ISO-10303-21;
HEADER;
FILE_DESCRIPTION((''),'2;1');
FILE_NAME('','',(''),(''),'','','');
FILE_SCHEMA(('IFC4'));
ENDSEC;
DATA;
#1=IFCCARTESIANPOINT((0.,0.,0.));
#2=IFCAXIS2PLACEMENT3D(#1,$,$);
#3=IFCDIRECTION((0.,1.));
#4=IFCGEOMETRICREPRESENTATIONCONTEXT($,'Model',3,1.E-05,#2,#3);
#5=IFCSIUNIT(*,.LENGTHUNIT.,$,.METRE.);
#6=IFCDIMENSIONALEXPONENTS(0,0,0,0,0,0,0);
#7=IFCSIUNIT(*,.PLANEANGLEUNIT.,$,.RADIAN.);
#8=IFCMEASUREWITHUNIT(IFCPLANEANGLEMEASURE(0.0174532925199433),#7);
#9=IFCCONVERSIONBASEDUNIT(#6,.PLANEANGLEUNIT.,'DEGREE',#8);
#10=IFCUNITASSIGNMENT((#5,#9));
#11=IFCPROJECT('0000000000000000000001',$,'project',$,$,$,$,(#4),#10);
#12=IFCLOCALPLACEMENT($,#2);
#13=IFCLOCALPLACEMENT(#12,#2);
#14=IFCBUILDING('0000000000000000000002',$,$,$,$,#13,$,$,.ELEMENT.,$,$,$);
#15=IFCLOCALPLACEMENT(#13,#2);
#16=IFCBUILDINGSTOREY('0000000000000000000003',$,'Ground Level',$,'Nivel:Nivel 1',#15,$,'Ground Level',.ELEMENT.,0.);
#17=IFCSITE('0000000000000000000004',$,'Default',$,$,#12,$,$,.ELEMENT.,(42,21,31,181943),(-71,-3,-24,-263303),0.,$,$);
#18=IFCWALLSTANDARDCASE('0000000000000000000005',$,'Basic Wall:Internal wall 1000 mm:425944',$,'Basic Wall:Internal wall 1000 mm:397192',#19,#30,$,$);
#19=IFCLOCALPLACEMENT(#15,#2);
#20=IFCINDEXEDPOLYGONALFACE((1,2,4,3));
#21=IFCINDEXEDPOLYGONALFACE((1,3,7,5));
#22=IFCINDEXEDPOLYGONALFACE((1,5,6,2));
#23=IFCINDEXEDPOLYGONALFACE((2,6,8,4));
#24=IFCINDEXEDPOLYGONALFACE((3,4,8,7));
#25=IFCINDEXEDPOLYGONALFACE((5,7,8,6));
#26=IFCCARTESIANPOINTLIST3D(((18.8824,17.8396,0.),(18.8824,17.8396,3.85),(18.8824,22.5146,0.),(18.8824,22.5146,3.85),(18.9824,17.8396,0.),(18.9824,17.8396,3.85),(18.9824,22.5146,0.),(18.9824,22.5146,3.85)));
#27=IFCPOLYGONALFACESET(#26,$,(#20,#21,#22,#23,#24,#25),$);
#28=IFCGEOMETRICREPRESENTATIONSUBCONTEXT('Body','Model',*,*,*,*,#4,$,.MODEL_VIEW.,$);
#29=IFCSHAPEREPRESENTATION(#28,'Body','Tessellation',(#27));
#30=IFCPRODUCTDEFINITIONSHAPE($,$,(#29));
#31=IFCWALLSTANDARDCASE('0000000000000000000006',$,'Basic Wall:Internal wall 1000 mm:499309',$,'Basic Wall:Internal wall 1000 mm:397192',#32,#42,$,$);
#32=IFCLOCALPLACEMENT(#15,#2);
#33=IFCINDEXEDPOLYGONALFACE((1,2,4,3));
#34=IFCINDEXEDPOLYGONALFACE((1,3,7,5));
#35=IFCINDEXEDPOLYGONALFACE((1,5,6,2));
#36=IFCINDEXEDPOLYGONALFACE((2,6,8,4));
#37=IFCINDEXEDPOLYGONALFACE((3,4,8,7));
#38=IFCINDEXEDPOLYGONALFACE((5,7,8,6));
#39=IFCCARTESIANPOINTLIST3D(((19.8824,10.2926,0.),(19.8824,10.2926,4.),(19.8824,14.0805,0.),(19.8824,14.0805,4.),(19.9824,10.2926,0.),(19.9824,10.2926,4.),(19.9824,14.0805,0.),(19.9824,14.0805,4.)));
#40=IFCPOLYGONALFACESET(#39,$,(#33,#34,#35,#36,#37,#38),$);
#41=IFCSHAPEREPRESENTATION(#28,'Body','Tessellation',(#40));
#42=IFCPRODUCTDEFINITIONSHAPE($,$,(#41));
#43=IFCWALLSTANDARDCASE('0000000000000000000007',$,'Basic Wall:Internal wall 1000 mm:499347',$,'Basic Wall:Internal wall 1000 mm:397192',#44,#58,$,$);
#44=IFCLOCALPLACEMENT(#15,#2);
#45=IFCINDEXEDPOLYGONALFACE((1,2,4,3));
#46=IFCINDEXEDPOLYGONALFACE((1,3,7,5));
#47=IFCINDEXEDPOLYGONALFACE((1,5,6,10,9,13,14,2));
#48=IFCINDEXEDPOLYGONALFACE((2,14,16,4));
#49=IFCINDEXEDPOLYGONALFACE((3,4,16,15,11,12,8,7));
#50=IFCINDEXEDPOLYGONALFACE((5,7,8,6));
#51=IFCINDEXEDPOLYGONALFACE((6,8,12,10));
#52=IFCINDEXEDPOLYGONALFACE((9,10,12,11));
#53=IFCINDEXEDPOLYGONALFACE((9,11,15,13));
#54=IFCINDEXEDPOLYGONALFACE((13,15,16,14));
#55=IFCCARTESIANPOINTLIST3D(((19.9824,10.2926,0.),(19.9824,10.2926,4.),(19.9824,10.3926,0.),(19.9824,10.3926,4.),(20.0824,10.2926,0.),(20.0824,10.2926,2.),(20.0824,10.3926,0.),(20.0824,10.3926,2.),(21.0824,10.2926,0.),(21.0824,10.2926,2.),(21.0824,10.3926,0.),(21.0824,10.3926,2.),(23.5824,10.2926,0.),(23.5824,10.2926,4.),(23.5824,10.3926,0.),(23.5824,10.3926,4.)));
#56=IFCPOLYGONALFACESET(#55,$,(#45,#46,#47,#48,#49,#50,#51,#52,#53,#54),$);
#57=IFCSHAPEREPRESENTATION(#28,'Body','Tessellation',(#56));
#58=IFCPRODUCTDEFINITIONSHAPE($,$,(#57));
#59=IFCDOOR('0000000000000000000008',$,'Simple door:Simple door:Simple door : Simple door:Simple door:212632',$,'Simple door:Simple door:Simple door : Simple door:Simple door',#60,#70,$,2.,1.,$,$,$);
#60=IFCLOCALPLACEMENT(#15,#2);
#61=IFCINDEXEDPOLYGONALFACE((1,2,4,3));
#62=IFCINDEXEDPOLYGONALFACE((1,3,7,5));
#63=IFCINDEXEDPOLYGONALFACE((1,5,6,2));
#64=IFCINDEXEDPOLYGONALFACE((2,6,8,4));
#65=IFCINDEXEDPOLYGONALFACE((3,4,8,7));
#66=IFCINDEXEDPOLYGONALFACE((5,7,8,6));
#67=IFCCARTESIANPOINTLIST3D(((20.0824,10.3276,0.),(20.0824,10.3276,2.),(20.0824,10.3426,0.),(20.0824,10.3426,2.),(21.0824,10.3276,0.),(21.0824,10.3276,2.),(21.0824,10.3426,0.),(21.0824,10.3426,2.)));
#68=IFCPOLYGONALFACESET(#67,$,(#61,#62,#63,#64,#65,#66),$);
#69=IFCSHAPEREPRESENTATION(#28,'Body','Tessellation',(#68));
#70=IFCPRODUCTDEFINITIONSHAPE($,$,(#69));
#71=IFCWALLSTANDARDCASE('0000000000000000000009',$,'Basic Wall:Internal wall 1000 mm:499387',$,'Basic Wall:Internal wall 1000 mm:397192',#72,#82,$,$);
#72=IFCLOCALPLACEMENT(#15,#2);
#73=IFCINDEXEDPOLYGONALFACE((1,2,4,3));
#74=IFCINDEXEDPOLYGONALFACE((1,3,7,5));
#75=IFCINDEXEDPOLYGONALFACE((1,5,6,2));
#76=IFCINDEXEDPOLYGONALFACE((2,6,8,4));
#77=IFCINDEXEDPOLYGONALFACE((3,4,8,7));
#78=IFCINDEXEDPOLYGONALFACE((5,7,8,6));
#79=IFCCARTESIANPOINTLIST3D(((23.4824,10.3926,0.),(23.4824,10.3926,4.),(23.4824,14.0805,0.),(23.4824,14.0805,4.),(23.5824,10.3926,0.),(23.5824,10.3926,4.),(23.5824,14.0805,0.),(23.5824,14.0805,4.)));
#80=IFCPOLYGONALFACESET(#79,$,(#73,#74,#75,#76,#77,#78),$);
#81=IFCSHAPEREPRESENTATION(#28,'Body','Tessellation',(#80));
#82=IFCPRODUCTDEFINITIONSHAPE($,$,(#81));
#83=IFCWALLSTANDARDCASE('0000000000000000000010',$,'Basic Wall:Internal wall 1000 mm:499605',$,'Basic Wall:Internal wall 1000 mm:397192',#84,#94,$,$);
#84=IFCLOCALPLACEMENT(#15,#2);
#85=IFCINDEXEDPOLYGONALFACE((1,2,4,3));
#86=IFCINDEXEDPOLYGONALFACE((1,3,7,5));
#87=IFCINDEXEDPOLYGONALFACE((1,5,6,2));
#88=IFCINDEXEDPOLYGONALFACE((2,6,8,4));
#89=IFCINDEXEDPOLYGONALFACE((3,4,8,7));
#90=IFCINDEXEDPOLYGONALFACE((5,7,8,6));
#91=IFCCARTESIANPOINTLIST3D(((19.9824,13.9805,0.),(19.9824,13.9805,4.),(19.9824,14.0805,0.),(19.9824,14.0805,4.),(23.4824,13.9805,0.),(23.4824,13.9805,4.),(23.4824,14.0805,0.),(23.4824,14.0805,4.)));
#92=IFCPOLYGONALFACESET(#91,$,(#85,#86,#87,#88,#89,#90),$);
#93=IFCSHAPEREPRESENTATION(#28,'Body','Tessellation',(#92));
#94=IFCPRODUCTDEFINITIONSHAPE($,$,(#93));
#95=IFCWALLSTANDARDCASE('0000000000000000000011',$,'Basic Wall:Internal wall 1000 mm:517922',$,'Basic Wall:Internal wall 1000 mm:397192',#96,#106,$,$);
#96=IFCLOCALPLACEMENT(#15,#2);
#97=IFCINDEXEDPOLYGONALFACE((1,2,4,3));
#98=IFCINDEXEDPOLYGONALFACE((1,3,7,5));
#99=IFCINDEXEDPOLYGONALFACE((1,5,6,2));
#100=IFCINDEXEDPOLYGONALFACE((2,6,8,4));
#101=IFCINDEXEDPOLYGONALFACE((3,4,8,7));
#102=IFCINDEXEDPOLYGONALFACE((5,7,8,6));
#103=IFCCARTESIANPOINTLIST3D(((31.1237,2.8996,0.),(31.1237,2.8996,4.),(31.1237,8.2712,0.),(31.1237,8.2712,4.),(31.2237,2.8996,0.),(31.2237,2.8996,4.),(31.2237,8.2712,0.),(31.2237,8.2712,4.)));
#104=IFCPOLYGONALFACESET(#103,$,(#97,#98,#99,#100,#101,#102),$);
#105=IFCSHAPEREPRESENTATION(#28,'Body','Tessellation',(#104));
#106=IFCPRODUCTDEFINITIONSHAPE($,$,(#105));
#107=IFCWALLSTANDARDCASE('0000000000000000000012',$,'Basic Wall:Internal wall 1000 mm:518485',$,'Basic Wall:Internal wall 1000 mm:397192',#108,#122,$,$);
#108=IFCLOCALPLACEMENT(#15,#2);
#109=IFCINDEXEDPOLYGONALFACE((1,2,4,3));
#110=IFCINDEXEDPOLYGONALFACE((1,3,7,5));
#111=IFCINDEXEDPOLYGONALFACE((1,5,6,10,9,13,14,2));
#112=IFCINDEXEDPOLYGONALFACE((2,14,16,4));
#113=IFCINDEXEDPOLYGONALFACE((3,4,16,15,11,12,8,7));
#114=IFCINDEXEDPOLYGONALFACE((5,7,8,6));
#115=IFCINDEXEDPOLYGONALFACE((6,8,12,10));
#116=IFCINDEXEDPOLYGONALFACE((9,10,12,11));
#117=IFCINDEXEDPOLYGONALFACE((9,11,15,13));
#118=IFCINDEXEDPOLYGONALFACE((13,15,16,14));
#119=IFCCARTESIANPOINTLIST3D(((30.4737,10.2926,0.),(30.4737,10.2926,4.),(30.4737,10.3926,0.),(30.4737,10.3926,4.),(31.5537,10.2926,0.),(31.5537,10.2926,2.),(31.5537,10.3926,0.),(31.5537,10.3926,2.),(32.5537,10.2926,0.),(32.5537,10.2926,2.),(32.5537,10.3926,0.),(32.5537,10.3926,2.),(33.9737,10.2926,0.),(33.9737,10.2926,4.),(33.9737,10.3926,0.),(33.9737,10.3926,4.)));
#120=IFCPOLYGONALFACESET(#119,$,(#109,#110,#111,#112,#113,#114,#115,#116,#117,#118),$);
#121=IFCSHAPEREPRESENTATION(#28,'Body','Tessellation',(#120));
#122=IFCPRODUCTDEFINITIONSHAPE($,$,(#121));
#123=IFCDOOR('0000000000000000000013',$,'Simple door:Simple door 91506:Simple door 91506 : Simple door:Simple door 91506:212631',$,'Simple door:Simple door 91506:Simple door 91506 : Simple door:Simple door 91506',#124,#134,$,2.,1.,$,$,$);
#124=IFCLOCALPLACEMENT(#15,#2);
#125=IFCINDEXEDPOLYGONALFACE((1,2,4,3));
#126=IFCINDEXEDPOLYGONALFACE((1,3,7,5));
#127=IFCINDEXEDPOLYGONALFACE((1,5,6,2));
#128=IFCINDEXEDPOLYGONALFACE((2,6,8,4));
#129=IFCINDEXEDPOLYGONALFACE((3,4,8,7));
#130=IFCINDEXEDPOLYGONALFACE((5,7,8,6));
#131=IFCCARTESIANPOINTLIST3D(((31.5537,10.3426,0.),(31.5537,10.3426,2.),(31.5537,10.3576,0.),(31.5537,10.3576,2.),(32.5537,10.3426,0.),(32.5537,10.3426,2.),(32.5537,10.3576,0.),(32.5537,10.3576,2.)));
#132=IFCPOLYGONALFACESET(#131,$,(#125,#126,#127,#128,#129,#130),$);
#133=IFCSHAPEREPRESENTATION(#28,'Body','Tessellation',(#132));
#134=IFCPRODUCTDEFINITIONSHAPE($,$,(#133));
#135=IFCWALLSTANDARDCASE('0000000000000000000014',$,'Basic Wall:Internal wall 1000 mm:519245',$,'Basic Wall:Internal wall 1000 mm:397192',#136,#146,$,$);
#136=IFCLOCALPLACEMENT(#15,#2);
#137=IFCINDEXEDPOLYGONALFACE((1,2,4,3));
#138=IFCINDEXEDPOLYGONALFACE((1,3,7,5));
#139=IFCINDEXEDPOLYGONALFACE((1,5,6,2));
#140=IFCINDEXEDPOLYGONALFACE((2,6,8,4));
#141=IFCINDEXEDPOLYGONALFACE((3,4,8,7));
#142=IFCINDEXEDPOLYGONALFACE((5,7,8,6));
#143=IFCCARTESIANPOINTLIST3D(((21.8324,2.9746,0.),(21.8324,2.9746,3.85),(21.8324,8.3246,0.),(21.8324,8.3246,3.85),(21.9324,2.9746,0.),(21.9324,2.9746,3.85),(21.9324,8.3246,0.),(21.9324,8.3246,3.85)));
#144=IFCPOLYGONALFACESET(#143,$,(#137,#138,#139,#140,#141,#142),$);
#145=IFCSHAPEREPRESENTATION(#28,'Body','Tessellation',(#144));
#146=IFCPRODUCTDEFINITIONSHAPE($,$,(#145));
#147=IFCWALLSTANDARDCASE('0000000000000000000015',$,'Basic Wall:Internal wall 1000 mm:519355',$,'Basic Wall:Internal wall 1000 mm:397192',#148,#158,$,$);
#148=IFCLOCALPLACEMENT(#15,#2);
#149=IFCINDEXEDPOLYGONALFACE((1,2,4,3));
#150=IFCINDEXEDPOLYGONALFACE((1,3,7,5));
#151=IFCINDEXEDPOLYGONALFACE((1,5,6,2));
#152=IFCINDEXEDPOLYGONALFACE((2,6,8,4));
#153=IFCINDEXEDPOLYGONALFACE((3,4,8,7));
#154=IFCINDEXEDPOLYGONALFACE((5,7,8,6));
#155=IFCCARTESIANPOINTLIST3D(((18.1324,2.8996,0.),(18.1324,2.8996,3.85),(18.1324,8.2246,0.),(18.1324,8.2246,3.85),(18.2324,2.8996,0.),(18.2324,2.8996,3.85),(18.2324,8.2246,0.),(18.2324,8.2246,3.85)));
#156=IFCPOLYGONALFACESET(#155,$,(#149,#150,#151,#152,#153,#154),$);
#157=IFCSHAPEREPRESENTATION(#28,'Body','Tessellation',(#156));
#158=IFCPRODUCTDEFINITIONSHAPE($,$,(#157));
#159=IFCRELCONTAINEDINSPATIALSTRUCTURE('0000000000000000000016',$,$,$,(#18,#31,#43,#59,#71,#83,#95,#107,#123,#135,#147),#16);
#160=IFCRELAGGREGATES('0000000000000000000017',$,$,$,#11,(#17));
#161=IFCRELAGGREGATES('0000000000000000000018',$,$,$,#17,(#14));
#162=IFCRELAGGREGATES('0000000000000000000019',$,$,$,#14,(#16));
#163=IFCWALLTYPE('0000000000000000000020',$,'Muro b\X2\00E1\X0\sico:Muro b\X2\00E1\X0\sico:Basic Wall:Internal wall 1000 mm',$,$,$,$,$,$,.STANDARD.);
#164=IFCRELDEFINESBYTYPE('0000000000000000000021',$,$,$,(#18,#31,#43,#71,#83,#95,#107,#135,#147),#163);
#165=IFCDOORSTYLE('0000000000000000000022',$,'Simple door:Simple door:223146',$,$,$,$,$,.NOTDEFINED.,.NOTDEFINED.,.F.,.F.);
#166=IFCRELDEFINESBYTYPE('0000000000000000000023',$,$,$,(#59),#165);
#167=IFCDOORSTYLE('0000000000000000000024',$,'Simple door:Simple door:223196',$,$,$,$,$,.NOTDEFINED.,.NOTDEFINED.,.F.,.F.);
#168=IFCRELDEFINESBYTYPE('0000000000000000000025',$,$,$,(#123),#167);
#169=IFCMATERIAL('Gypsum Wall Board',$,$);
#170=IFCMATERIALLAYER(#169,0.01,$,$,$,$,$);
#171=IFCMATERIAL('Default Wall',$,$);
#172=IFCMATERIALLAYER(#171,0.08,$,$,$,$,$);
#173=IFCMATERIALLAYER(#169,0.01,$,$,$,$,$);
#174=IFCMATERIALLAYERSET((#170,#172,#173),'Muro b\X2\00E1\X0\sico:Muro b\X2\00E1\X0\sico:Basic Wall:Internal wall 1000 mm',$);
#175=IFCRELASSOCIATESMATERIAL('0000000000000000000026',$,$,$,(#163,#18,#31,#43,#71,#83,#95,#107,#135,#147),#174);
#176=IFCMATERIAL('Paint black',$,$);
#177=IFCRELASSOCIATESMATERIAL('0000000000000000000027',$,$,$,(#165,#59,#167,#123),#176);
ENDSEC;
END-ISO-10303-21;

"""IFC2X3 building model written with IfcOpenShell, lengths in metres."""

from ifc_helpers import new_model, entity, si_unit, converted_unit, direction, frame, frame_2d, origin, origin_2d_with_axis, place, context, subcontext, project, spatial, rectangle, extrude, source, transform, mapped, material, layer, layer_set, layer_usage, type_object, type_shapes, element, fill, save


model = new_model("IFC2X3")

# Units and contexts
model_context = context("Model", 3, precision=1e-05, world=origin(), true_north=direction((0.0, 1.0)))
body_context = subcontext(model_context, "Body", "Model", "MODEL_VIEW")
ifc_project = project(units=[si_unit("LENGTHUNIT", "METRE"), converted_unit("PLANEANGLEUNIT", "DEGREE", entity("IfcPlaneAngleMeasure", 0.0174532925199433), si_unit("PLANEANGLEUNIT", "RADIAN"), dimensions=[0, 0, 0, 0, 0, 0, 0])], contexts=[model_context])

# Site, building, storey
site_placement = place(None, origin())
site = spatial("IfcSite", under=ifc_project, at=site_placement, Name="Default", CompositionType="ELEMENT", RefLatitude=(42, 21, 31, 181943), RefLongitude=(-71, -3, -24, -263303), RefElevation=0.0)
building_placement = place(site_placement, origin())
building = spatial("IfcBuilding", under=site, at=building_placement, CompositionType="ELEMENT")
storey_placement = place(building_placement, origin())
storey = spatial("IfcBuildingStorey", under=building, at=storey_placement, Name="Ground Level", ObjectType="Nivel:Nivel 1", LongName="Ground Level", CompositionType="ELEMENT", Elevation=0.0)

# Walls
ifc_material_1 = material(Name="Gypsum Wall Board")
ifc_layer_1 = layer(ifc_material_1, 0.01)
ifc_material_2 = material(Name="Default Wall")
ifc_layer_2 = layer(ifc_material_2, 0.08)
ifc_layer_3 = layer(ifc_material_1, 0.01)
ifc_layer_set = layer_set([ifc_layer_1, ifc_layer_2, ifc_layer_3], Name="Muro básico:Muro básico:Basic Wall:Internal wall 1000 mm")
ifc_layer_usage_1 = layer_usage(ifc_layer_set, "AXIS2", "NEGATIVE", 0.05)
wall_type = type_object("IfcWallType", Name="Muro básico:Muro básico:Basic Wall:Internal wall 1000 mm", PredefinedType="STANDARD", material=ifc_layer_set)
wall_1_placement = place(storey_placement, frame((18.9324, 17.8396, 0.0), z_axis=(0.0, 0.0, 1.0), x_axis=(0.0, 1.0, 0.0)))
element("IfcWallStandardCase", 1, at=wall_1_placement, inside=storey, type_object=wall_type, material=ifc_layer_usage_1, Name="Basic Wall:Internal wall 1000 mm:425944", ObjectType="Basic Wall:Internal wall 1000 mm:397192", context=body_context, shape_type="SweptSolid", body=[
    extrude(rectangle(XDim=4.675, YDim=0.1, at=frame_2d((2.3375, 0.0), x_axis=(-1.0, 0.0))), origin(), (0.0, 0.0, 1.0), 3.85),
])
ifc_layer_usage_2 = layer_usage(ifc_layer_set, "AXIS2", "NEGATIVE", 0.05)
wall_2_placement = place(storey_placement, frame((19.9324, 14.0805, 0.0), z_axis=(0.0, 0.0, 1.0), x_axis=(0.0, -1.0, 0.0)))
element("IfcWallStandardCase", 2, at=wall_2_placement, inside=storey, type_object=wall_type, material=ifc_layer_usage_2, Name="Basic Wall:Internal wall 1000 mm:499309", ObjectType="Basic Wall:Internal wall 1000 mm:397192", context=body_context, shape_type="SweptSolid", body=[
    extrude(rectangle(XDim=3.7879, YDim=0.1, at=frame_2d((1.894, 0.0), x_axis=(-1.0, 0.0))), origin(), (0.0, 0.0, 1.0), 4.0),
])

# Wall, opening, door
ifc_layer_usage_3 = layer_usage(ifc_layer_set, "AXIS2", "NEGATIVE", 0.05)
wall_3_placement = place(storey_placement, frame((19.9824, 10.3426, 0.0)))
wall_3 = element("IfcWallStandardCase", 3, at=wall_3_placement, inside=storey, type_object=wall_type, material=ifc_layer_usage_3, Name="Basic Wall:Internal wall 1000 mm:499347", ObjectType="Basic Wall:Internal wall 1000 mm:397192", context=body_context, shape_type="SweptSolid", body=[
    extrude(rectangle(XDim=3.6, YDim=0.1, at=frame_2d((1.8, 0.0), x_axis=(-1.0, 0.0))), origin(), (0.0, 0.0, 1.0), 4.0),
])
opening_1_placement = place(wall_3_placement, frame((-19.9824, -10.3426, 0.0)))
opening_1 = element("IfcOpeningElement", 4, at=opening_1_placement, cuts=wall_3, ObjectType="Opening", context=body_context, shape_type="SweptSolid", body=[
    extrude(rectangle(XDim=2.0, YDim=1.0, at=frame_2d((0.0, 0.0), x_axis=(0.0, 1.0))), frame((20.5824, 10.2906, 1.0), z_axis=(0.0, 1.0, 0.0), x_axis=(-1.0, 0.0, 0.0)), (0.0, 0.0, 1.0), 0.104),
])
ifc_material_3 = material(Name="Paint black")
door_style_1 = type_object("IfcDoorStyle", Name="Simple door:Simple door:223146", ConstructionType="NOTDEFINED", OperationType="NOTDEFINED", ParameterTakesPrecedence=False, Sizeable=False, material=ifc_material_3)
shared_shape_1 = source(origin(), body_context, "Body", "SweptSolid", [
    extrude(rectangle(XDim=1.0, YDim=0.015, at=origin_2d_with_axis()), frame((0.5, -0.0595, 0.0)), (0.0, 0.0, 1.0), 2.0),
])
type_shapes(door_style_1, [shared_shape_1])
door_1_placement = place(opening_1_placement, frame((20.0824, 10.3946, 0.0)))
door_1 = element("IfcDoor", 5, at=door_1_placement, inside=storey, type_object=door_style_1, material=ifc_material_3, Name="Simple door:Simple door:Simple door : Simple door:Simple door:212632", ObjectType="Simple door:Simple door:Simple door : Simple door:Simple door", OverallHeight=2.0, OverallWidth=1.0, context=body_context, shape_type="MappedRepresentation", body=[
    mapped(shared_shape_1, transform((0.0, 0.0, 0.0), scale=1.0)),
])
fill(opening_1, door_1)

# Walls
ifc_layer_usage_4 = layer_usage(ifc_layer_set, "AXIS2", "NEGATIVE", 0.05)
wall_4_placement = place(storey_placement, frame((23.5324, 10.3926, 0.0), z_axis=(0.0, 0.0, 1.0), x_axis=(0.0, 1.0, 0.0)))
element("IfcWallStandardCase", 6, at=wall_4_placement, inside=storey, type_object=wall_type, material=ifc_layer_usage_4, Name="Basic Wall:Internal wall 1000 mm:499387", ObjectType="Basic Wall:Internal wall 1000 mm:397192", context=body_context, shape_type="SweptSolid", body=[
    extrude(rectangle(XDim=3.6879, YDim=0.1, at=frame_2d((1.844, 0.0), x_axis=(-1.0, 0.0))), origin(), (0.0, 0.0, 1.0), 4.0),
])
ifc_layer_usage_5 = layer_usage(ifc_layer_set, "AXIS2", "NEGATIVE", 0.05)
wall_5_placement = place(storey_placement, frame((19.9824, 14.0305, 0.0)))
element("IfcWallStandardCase", 7, at=wall_5_placement, inside=storey, type_object=wall_type, material=ifc_layer_usage_5, Name="Basic Wall:Internal wall 1000 mm:499605", ObjectType="Basic Wall:Internal wall 1000 mm:397192", context=body_context, shape_type="SweptSolid", body=[
    extrude(rectangle(XDim=3.5, YDim=0.1, at=frame_2d((1.75, 0.0), x_axis=(-1.0, 0.0))), origin(), (0.0, 0.0, 1.0), 4.0),
])
ifc_layer_usage_6 = layer_usage(ifc_layer_set, "AXIS2", "NEGATIVE", 0.05)
wall_6_placement = place(storey_placement, frame((31.1737, 8.2712, 0.0), z_axis=(0.0, 0.0, 1.0), x_axis=(0.0, -1.0, 0.0)))
element("IfcWallStandardCase", 8, at=wall_6_placement, inside=storey, type_object=wall_type, material=ifc_layer_usage_6, Name="Basic Wall:Internal wall 1000 mm:517922", ObjectType="Basic Wall:Internal wall 1000 mm:397192", context=body_context, shape_type="SweptSolid", body=[
    extrude(rectangle(XDim=5.3716, YDim=0.1, at=frame_2d((2.6858, 0.0), x_axis=(-1.0, 0.0))), origin(), (0.0, 0.0, 1.0), 4.0),
])

# Shared definitions
door_style_2 = type_object("IfcDoorStyle", Name="Simple door:Simple door:223196", ConstructionType="NOTDEFINED", OperationType="NOTDEFINED", ParameterTakesPrecedence=False, Sizeable=False, material=ifc_material_3)
shared_shape_2 = source(origin(), body_context, "Body", "SweptSolid", [
    extrude(rectangle(XDim=1.0, YDim=0.015, at=origin_2d_with_axis()), frame((0.5, 0.0445, 0.0)), (0.0, 0.0, 1.0), 2.0),
])
type_shapes(door_style_2, [shared_shape_2])

# Wall, opening, door
ifc_layer_usage_7 = layer_usage(ifc_layer_set, "AXIS2", "NEGATIVE", 0.05)
wall_7_placement = place(storey_placement, frame((30.4737, 10.3426, 0.0)))
wall_7 = element("IfcWallStandardCase", 9, at=wall_7_placement, inside=storey, type_object=wall_type, material=ifc_layer_usage_7, Name="Basic Wall:Internal wall 1000 mm:518485", ObjectType="Basic Wall:Internal wall 1000 mm:397192", context=body_context, shape_type="SweptSolid", body=[
    extrude(rectangle(XDim=3.5, YDim=0.1, at=frame_2d((1.75, 0.0), x_axis=(1.0, 0.0))), origin(), (0.0, 0.0, 1.0), 4.0),
])
opening_2_placement = place(wall_7_placement, frame((-30.4737, -10.3426, 0.0)))
opening_2 = element("IfcOpeningElement", 10, at=opening_2_placement, cuts=wall_7, ObjectType="Opening", context=body_context, shape_type="SweptSolid", body=[
    extrude(rectangle(XDim=2.0, YDim=1.0, at=frame_2d((0.0, 0.0), x_axis=(0.0, 1.0))), frame((32.0537, 10.2906, 1.0), z_axis=(0.0, 1.0, 0.0), x_axis=(-1.0, 0.0, 0.0)), (0.0, 0.0, 1.0), 0.104),
])
door_2_placement = place(opening_2_placement, frame((32.5537, 10.3946, 0.0), z_axis=(0.0, 0.0, 1.0), x_axis=(-1.0, 0.0, 0.0)))
door_2 = element("IfcDoor", 11, at=door_2_placement, inside=storey, type_object=door_style_2, material=ifc_material_3, Name="Simple door:Simple door 91506:Simple door 91506 : Simple door:Simple door 91506:212631", ObjectType="Simple door:Simple door 91506:Simple door 91506 : Simple door:Simple door 91506", OverallHeight=2.0, OverallWidth=1.0, context=body_context, shape_type="MappedRepresentation", body=[
    mapped(shared_shape_2, transform((0.0, 0.0, 0.0), scale=1.0)),
])
fill(opening_2, door_2)

# Wall
ifc_layer_usage_8 = layer_usage(ifc_layer_set, "AXIS2", "NEGATIVE", 0.05)
wall_8_placement = place(storey_placement, frame((21.8824, 2.9746, 0.0), z_axis=(0.0, 0.0, 1.0), x_axis=(0.0, 1.0, 0.0)))
element("IfcWallStandardCase", 12, at=wall_8_placement, inside=storey, type_object=wall_type, material=ifc_layer_usage_8, Name="Basic Wall:Internal wall 1000 mm:519245", ObjectType="Basic Wall:Internal wall 1000 mm:397192", context=body_context, shape_type="SweptSolid", body=[
    extrude(rectangle(XDim=5.35, YDim=0.1, at=frame_2d((2.675, 0.0), x_axis=(-1.0, 0.0))), origin(), (0.0, 0.0, 1.0), 3.85),
])

# Wall
ifc_layer_usage_9 = layer_usage(ifc_layer_set, "AXIS2", "NEGATIVE", 0.05)
wall_9_placement = place(storey_placement, frame((18.1824, 8.2246, 0.0), z_axis=(0.0, 0.0, 1.0), x_axis=(0.0, -1.0, 0.0)))
element("IfcWallStandardCase", 13, at=wall_9_placement, inside=storey, type_object=wall_type, material=ifc_layer_usage_9, Name="Basic Wall:Internal wall 1000 mm:519355", ObjectType="Basic Wall:Internal wall 1000 mm:397192", context=body_context, shape_type="SweptSolid", body=[
    extrude(rectangle(XDim=5.325, YDim=0.1, at=frame_2d((2.6625, 0.0), x_axis=(-1.0, 0.0))), origin(), (0.0, 0.0, 1.0), 3.85),
])

save(model, "model.ifc")
